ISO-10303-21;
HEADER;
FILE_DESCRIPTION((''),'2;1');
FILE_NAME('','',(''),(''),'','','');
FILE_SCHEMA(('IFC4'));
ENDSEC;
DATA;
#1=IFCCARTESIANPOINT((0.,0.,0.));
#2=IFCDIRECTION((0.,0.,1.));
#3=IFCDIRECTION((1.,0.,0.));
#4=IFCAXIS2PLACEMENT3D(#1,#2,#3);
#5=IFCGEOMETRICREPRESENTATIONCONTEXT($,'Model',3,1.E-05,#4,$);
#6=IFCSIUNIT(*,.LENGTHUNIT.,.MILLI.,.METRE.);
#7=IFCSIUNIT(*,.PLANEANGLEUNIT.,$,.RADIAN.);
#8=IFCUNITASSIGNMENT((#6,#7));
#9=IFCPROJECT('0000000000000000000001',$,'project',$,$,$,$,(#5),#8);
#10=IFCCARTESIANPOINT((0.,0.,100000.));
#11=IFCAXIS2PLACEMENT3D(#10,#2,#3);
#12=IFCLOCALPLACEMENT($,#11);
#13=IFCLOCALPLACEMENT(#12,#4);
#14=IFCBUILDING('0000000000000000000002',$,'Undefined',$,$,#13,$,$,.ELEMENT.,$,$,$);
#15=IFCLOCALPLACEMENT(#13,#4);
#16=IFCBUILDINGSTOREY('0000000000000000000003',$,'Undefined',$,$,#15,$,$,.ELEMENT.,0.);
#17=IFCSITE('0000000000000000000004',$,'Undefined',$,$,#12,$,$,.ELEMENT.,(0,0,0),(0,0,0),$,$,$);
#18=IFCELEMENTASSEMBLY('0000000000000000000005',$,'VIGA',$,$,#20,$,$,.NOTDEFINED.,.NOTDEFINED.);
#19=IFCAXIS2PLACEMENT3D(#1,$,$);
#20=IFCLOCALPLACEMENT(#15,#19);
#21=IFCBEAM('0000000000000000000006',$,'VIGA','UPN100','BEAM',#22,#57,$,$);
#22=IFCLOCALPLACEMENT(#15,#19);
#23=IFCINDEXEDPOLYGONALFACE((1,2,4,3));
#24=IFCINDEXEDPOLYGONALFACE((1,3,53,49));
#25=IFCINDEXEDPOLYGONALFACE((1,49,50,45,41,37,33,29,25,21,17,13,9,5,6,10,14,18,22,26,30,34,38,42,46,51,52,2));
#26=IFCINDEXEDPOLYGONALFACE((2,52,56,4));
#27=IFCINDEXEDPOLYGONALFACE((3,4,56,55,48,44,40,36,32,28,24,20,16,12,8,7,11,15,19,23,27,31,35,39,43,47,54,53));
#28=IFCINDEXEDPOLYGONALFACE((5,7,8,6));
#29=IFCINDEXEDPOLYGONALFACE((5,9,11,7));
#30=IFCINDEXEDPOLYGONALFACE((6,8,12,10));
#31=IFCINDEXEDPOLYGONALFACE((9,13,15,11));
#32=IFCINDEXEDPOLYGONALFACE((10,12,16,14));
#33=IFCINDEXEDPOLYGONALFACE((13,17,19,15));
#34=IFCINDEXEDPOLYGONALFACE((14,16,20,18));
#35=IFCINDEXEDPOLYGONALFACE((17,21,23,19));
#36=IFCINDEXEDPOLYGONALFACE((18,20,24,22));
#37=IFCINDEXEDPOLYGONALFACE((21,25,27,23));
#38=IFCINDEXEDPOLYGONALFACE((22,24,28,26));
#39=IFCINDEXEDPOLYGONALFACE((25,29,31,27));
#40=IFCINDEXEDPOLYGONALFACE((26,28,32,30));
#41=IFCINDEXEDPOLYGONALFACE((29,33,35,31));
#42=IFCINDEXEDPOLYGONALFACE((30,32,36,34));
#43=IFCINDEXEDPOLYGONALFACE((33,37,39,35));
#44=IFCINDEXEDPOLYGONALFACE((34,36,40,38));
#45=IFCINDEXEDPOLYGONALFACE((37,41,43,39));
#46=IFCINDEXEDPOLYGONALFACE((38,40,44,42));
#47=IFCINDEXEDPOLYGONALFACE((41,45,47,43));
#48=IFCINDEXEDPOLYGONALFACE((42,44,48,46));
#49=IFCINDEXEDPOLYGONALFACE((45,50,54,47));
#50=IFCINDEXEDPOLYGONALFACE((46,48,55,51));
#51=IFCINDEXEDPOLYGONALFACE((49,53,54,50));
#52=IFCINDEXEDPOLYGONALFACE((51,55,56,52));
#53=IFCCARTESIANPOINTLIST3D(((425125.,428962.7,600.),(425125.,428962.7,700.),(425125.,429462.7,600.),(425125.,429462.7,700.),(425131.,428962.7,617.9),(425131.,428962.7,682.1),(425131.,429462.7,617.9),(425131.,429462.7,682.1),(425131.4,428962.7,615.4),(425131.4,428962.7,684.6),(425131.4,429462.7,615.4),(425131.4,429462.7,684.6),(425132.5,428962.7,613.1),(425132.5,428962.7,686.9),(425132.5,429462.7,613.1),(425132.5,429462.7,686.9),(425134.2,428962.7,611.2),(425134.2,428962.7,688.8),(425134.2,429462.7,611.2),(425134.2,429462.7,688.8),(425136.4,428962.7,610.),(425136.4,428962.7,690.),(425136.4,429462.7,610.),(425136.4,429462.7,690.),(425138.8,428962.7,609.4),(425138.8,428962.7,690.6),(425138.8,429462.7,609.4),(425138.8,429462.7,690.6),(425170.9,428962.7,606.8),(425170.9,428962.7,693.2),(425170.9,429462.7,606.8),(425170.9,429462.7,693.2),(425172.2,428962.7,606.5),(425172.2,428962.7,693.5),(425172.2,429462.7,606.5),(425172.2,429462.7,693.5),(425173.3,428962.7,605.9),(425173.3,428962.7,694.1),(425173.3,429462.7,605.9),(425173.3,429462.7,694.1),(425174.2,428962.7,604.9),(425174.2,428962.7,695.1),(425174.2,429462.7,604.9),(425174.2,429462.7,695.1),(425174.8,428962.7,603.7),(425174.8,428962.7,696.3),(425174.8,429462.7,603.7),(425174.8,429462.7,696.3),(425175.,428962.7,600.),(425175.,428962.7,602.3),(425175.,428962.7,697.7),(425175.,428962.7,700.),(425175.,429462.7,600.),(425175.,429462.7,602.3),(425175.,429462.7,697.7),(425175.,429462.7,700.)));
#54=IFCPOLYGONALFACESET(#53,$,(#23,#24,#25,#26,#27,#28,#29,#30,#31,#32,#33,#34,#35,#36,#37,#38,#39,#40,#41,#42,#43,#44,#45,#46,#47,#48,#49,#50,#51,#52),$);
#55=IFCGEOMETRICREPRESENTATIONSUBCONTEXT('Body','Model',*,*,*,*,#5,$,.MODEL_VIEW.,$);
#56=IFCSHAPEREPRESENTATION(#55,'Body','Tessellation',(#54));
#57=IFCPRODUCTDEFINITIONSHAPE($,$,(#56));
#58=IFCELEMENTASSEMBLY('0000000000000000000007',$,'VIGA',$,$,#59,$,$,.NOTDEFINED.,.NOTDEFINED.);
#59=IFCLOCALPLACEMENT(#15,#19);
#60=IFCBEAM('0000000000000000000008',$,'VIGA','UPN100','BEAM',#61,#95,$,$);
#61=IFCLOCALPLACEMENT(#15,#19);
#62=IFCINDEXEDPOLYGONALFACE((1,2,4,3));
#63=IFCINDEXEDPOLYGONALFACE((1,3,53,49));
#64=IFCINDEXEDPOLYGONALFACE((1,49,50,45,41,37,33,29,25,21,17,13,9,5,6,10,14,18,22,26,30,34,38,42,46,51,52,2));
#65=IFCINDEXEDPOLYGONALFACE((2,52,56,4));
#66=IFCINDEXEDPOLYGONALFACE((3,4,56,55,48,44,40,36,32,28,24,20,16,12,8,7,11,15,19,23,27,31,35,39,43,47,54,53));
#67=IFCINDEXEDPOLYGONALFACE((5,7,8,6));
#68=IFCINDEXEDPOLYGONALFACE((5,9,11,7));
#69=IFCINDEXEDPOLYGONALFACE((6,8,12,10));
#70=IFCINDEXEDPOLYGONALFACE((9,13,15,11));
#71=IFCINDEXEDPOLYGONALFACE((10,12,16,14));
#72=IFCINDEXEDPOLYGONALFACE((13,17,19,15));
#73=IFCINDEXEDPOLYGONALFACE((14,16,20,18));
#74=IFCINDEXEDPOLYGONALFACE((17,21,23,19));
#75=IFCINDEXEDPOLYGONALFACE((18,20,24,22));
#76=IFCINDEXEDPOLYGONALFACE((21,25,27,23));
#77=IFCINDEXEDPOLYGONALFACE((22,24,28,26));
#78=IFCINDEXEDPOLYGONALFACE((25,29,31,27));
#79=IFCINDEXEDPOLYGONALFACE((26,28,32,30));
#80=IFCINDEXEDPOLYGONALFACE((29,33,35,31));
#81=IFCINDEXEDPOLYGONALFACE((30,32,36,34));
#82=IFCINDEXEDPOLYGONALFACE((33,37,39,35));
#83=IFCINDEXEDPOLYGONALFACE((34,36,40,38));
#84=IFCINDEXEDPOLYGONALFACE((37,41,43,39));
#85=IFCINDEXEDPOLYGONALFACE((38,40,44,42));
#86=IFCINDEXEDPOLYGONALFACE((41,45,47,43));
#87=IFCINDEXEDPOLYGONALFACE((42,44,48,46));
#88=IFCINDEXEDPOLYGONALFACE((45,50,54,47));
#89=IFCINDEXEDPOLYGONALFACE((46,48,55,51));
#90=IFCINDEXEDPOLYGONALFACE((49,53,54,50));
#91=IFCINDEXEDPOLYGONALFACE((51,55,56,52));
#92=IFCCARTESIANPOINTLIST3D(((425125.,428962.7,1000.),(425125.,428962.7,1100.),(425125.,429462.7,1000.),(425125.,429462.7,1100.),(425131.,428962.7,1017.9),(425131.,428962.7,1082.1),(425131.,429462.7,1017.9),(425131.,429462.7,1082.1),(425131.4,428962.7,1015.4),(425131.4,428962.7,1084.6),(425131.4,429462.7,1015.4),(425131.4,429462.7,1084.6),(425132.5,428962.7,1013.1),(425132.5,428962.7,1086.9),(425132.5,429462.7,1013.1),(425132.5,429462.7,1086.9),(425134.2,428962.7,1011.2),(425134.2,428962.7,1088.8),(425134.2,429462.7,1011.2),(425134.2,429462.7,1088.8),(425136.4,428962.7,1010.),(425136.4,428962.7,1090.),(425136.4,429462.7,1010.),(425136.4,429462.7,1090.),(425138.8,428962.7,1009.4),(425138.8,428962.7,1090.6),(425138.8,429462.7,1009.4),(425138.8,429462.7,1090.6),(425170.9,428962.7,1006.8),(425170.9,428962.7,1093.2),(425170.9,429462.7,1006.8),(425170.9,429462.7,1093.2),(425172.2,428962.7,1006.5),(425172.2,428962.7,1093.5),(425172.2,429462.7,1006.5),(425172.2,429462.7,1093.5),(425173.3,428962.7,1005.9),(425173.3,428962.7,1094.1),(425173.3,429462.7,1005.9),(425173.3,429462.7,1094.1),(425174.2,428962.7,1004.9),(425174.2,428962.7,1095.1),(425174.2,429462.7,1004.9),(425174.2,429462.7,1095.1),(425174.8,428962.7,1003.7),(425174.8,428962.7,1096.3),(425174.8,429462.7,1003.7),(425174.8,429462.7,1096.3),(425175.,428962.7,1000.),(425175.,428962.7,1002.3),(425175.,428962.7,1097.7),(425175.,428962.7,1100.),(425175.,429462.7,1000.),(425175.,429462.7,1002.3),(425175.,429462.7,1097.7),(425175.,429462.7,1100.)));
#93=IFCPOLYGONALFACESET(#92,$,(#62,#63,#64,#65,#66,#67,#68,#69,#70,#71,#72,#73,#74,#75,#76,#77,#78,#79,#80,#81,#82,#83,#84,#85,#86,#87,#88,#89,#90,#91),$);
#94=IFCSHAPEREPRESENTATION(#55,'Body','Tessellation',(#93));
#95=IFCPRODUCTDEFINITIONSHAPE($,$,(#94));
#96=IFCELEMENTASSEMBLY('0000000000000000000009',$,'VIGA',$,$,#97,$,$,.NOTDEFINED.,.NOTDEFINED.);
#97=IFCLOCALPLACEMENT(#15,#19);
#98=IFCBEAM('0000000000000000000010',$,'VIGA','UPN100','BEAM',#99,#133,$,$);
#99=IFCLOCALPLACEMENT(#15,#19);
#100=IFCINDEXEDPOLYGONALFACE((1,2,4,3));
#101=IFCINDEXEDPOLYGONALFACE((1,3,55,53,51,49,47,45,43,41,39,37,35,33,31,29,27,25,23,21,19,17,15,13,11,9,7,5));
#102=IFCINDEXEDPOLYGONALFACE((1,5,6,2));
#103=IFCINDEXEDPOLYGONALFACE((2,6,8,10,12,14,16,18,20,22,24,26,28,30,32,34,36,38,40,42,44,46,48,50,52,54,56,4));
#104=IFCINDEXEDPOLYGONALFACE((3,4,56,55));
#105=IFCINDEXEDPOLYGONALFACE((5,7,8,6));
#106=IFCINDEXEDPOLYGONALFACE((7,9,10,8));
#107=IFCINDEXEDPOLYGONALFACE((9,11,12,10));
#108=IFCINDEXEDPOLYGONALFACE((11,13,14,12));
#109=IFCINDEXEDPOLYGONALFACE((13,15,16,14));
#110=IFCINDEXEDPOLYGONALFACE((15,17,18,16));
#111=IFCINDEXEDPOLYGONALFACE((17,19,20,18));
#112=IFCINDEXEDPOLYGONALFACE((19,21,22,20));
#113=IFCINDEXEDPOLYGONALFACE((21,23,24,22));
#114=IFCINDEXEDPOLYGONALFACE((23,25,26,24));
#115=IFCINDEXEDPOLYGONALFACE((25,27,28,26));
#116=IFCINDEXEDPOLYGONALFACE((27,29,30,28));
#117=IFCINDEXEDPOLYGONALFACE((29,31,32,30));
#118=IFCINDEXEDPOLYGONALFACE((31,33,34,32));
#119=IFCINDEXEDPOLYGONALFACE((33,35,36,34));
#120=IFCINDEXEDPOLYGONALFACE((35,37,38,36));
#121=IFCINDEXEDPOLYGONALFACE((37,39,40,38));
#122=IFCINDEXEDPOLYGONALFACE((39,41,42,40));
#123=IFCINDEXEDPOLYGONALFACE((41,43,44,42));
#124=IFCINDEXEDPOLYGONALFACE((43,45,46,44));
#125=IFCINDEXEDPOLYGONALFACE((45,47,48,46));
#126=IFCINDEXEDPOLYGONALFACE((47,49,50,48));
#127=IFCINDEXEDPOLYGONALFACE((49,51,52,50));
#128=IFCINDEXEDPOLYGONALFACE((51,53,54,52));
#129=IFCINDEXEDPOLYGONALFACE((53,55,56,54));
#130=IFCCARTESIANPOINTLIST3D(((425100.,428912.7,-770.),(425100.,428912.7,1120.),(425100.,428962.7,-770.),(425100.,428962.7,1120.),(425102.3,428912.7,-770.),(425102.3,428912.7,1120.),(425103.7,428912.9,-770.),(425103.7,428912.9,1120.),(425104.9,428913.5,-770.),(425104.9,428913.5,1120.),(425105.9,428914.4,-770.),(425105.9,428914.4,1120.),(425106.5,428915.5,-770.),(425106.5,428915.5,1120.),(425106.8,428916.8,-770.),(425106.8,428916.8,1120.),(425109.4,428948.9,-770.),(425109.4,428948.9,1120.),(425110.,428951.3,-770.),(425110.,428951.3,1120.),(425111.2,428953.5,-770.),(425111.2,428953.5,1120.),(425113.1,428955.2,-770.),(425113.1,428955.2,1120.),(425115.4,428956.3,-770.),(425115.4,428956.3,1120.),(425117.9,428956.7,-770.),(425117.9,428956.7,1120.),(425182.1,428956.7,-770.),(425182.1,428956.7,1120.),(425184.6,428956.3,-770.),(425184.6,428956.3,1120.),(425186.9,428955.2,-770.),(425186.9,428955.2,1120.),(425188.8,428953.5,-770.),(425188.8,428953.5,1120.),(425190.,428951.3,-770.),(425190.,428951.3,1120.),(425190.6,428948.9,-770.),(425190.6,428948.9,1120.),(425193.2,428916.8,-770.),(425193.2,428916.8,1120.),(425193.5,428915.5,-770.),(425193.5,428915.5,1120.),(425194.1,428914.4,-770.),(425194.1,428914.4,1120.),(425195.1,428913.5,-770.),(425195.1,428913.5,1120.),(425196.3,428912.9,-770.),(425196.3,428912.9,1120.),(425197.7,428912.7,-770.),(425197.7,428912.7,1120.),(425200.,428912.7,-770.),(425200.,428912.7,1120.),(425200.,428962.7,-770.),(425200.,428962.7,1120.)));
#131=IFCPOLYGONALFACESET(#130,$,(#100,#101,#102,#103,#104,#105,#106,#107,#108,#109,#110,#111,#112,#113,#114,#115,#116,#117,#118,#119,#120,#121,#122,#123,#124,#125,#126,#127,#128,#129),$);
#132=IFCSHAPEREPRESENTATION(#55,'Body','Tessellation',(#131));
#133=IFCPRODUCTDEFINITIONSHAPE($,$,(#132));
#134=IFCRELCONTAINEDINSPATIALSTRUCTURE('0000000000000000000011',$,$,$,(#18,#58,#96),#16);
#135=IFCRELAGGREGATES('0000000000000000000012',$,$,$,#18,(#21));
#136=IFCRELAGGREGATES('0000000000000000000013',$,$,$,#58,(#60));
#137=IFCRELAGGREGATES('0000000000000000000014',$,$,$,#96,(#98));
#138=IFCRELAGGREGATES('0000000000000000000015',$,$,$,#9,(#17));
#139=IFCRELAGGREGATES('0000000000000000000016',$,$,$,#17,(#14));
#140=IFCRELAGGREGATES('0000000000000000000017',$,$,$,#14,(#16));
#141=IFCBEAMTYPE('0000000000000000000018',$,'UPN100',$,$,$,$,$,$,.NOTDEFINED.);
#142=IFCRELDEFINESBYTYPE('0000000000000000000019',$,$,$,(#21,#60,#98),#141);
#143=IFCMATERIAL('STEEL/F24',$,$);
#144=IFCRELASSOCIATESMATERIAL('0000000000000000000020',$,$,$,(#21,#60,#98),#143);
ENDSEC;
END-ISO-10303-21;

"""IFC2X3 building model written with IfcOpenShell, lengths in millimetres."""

from ifc_helpers import new_model, si_unit, frame, origin_with_axes, origin_2d_with_axis, place, context, subcontext, project, spatial, u_section, extrude, material, type_object, element, aggregate, save


model = new_model("IFC2X3")

# Units and contexts
model_context = context("Model", 3, precision=1e-05, world=origin_with_axes())
body_context = subcontext(model_context, "Body", "Model", "MODEL_VIEW")
ifc_project = project(units=[si_unit("LENGTHUNIT", "METRE", prefix="MILLI"), si_unit("PLANEANGLEUNIT", "RADIAN")], contexts=[model_context])

# Site, building, storey
site_placement = place(None, frame((0.0, 0.0, 100000.0), z_axis=(0.0, 0.0, 1.0), x_axis=(1.0, 0.0, 0.0)))
site = spatial("IfcSite", under=ifc_project, at=site_placement, Name="Undefined", CompositionType="ELEMENT", RefLatitude=(0, 0, 0), RefLongitude=(0, 0, 0))
building_placement = place(site_placement, origin_with_axes())
building = spatial("IfcBuilding", under=site, at=building_placement, Name="Undefined", CompositionType="ELEMENT")
storey_placement = place(building_placement, origin_with_axes())
storey = spatial("IfcBuildingStorey", under=building, at=storey_placement, Name="Undefined", CompositionType="ELEMENT", Elevation=0.0)

# Element assemblies, beams
ifc_material_1 = material(Name="STEEL/F24")
beam_type = type_object("IfcBeamType", Name="UPN100", PredefinedType="NOTDEFINED")
assembly_1_placement = place(storey_placement, origin_with_axes())
assembly_1 = element("IfcElementAssembly", 1, at=assembly_1_placement, inside=storey, Name="VIGA", AssemblyPlace="NOTDEFINED", PredefinedType="NOTDEFINED")
beam_1_placement = place(assembly_1_placement, frame((425150.0, 428962.7, 650.0), z_axis=(0.0, 0.0, 1.0), x_axis=(0.0, 1.0, 0.0)))
beam_1 = element("IfcBeam", 2, at=beam_1_placement, type_object=beam_type, material=ifc_material_1, Name="VIGA", Description="UPN100", ObjectType="BEAM", context=body_context, shape_type="SweptSolid", body=[
    extrude(u_section(Depth=100.0, FlangeWidth=50.0, WebThickness=6.0, FlangeThickness=8.5, FilletRadius=8.5, EdgeRadius=4.5, FlangeSlope=0.07983, at=origin_2d_with_axis()), frame((500.0, 0.0, 0.0), z_axis=(-1.0, 0.0, 0.0), x_axis=(0.0, -1.0, 0.0)), (0.0, 0.0, 1.0), 500.0),
])
aggregate(assembly_1, [beam_1])
assembly_2_placement = place(storey_placement, origin_with_axes())
assembly_2 = element("IfcElementAssembly", 3, at=assembly_2_placement, inside=storey, Name="VIGA", AssemblyPlace="NOTDEFINED", PredefinedType="NOTDEFINED")
beam_2_placement = place(assembly_2_placement, frame((425150.0, 428962.7, 1050.0), z_axis=(0.0, 0.0, 1.0), x_axis=(0.0, 1.0, 0.0)))
beam_2 = element("IfcBeam", 4, at=beam_2_placement, type_object=beam_type, material=ifc_material_1, Name="VIGA", Description="UPN100", ObjectType="BEAM", context=body_context, shape_type="SweptSolid", body=[
    extrude(u_section(Depth=100.0, FlangeWidth=50.0, WebThickness=6.0, FlangeThickness=8.5, FilletRadius=8.5, EdgeRadius=4.5, FlangeSlope=0.07983, at=origin_2d_with_axis()), frame((500.0, 0.0, 0.0), z_axis=(-1.0, 0.0, 0.0), x_axis=(0.0, -1.0, 0.0)), (0.0, 0.0, 1.0), 500.0),
])
aggregate(assembly_2, [beam_2])
assembly_3_placement = place(storey_placement, origin_with_axes())
assembly_3 = element("IfcElementAssembly", 5, at=assembly_3_placement, inside=storey, Name="VIGA", AssemblyPlace="NOTDEFINED", PredefinedType="NOTDEFINED")
beam_3_placement = place(assembly_3_placement, frame((425150.0, 428937.7, 1120.0), z_axis=(1.0, 0.0, 0.0), x_axis=(0.0, 0.0, -1.0)))
beam_3 = element("IfcBeam", 6, at=beam_3_placement, type_object=beam_type, material=ifc_material_1, Name="VIGA", Description="UPN100", ObjectType="BEAM", context=body_context, shape_type="SweptSolid", body=[
    extrude(u_section(Depth=100.0, FlangeWidth=50.0, WebThickness=6.0, FlangeThickness=8.5, FilletRadius=8.5, EdgeRadius=4.5, FlangeSlope=0.07983, at=origin_2d_with_axis()), frame((1890.0, 0.0, 0.0), z_axis=(-1.0, 0.0, 0.0), x_axis=(0.0, -1.0, 0.0)), (0.0, 0.0, 1.0), 1890.0),
])
aggregate(assembly_3, [beam_3])

save(model, "model.ifc")
